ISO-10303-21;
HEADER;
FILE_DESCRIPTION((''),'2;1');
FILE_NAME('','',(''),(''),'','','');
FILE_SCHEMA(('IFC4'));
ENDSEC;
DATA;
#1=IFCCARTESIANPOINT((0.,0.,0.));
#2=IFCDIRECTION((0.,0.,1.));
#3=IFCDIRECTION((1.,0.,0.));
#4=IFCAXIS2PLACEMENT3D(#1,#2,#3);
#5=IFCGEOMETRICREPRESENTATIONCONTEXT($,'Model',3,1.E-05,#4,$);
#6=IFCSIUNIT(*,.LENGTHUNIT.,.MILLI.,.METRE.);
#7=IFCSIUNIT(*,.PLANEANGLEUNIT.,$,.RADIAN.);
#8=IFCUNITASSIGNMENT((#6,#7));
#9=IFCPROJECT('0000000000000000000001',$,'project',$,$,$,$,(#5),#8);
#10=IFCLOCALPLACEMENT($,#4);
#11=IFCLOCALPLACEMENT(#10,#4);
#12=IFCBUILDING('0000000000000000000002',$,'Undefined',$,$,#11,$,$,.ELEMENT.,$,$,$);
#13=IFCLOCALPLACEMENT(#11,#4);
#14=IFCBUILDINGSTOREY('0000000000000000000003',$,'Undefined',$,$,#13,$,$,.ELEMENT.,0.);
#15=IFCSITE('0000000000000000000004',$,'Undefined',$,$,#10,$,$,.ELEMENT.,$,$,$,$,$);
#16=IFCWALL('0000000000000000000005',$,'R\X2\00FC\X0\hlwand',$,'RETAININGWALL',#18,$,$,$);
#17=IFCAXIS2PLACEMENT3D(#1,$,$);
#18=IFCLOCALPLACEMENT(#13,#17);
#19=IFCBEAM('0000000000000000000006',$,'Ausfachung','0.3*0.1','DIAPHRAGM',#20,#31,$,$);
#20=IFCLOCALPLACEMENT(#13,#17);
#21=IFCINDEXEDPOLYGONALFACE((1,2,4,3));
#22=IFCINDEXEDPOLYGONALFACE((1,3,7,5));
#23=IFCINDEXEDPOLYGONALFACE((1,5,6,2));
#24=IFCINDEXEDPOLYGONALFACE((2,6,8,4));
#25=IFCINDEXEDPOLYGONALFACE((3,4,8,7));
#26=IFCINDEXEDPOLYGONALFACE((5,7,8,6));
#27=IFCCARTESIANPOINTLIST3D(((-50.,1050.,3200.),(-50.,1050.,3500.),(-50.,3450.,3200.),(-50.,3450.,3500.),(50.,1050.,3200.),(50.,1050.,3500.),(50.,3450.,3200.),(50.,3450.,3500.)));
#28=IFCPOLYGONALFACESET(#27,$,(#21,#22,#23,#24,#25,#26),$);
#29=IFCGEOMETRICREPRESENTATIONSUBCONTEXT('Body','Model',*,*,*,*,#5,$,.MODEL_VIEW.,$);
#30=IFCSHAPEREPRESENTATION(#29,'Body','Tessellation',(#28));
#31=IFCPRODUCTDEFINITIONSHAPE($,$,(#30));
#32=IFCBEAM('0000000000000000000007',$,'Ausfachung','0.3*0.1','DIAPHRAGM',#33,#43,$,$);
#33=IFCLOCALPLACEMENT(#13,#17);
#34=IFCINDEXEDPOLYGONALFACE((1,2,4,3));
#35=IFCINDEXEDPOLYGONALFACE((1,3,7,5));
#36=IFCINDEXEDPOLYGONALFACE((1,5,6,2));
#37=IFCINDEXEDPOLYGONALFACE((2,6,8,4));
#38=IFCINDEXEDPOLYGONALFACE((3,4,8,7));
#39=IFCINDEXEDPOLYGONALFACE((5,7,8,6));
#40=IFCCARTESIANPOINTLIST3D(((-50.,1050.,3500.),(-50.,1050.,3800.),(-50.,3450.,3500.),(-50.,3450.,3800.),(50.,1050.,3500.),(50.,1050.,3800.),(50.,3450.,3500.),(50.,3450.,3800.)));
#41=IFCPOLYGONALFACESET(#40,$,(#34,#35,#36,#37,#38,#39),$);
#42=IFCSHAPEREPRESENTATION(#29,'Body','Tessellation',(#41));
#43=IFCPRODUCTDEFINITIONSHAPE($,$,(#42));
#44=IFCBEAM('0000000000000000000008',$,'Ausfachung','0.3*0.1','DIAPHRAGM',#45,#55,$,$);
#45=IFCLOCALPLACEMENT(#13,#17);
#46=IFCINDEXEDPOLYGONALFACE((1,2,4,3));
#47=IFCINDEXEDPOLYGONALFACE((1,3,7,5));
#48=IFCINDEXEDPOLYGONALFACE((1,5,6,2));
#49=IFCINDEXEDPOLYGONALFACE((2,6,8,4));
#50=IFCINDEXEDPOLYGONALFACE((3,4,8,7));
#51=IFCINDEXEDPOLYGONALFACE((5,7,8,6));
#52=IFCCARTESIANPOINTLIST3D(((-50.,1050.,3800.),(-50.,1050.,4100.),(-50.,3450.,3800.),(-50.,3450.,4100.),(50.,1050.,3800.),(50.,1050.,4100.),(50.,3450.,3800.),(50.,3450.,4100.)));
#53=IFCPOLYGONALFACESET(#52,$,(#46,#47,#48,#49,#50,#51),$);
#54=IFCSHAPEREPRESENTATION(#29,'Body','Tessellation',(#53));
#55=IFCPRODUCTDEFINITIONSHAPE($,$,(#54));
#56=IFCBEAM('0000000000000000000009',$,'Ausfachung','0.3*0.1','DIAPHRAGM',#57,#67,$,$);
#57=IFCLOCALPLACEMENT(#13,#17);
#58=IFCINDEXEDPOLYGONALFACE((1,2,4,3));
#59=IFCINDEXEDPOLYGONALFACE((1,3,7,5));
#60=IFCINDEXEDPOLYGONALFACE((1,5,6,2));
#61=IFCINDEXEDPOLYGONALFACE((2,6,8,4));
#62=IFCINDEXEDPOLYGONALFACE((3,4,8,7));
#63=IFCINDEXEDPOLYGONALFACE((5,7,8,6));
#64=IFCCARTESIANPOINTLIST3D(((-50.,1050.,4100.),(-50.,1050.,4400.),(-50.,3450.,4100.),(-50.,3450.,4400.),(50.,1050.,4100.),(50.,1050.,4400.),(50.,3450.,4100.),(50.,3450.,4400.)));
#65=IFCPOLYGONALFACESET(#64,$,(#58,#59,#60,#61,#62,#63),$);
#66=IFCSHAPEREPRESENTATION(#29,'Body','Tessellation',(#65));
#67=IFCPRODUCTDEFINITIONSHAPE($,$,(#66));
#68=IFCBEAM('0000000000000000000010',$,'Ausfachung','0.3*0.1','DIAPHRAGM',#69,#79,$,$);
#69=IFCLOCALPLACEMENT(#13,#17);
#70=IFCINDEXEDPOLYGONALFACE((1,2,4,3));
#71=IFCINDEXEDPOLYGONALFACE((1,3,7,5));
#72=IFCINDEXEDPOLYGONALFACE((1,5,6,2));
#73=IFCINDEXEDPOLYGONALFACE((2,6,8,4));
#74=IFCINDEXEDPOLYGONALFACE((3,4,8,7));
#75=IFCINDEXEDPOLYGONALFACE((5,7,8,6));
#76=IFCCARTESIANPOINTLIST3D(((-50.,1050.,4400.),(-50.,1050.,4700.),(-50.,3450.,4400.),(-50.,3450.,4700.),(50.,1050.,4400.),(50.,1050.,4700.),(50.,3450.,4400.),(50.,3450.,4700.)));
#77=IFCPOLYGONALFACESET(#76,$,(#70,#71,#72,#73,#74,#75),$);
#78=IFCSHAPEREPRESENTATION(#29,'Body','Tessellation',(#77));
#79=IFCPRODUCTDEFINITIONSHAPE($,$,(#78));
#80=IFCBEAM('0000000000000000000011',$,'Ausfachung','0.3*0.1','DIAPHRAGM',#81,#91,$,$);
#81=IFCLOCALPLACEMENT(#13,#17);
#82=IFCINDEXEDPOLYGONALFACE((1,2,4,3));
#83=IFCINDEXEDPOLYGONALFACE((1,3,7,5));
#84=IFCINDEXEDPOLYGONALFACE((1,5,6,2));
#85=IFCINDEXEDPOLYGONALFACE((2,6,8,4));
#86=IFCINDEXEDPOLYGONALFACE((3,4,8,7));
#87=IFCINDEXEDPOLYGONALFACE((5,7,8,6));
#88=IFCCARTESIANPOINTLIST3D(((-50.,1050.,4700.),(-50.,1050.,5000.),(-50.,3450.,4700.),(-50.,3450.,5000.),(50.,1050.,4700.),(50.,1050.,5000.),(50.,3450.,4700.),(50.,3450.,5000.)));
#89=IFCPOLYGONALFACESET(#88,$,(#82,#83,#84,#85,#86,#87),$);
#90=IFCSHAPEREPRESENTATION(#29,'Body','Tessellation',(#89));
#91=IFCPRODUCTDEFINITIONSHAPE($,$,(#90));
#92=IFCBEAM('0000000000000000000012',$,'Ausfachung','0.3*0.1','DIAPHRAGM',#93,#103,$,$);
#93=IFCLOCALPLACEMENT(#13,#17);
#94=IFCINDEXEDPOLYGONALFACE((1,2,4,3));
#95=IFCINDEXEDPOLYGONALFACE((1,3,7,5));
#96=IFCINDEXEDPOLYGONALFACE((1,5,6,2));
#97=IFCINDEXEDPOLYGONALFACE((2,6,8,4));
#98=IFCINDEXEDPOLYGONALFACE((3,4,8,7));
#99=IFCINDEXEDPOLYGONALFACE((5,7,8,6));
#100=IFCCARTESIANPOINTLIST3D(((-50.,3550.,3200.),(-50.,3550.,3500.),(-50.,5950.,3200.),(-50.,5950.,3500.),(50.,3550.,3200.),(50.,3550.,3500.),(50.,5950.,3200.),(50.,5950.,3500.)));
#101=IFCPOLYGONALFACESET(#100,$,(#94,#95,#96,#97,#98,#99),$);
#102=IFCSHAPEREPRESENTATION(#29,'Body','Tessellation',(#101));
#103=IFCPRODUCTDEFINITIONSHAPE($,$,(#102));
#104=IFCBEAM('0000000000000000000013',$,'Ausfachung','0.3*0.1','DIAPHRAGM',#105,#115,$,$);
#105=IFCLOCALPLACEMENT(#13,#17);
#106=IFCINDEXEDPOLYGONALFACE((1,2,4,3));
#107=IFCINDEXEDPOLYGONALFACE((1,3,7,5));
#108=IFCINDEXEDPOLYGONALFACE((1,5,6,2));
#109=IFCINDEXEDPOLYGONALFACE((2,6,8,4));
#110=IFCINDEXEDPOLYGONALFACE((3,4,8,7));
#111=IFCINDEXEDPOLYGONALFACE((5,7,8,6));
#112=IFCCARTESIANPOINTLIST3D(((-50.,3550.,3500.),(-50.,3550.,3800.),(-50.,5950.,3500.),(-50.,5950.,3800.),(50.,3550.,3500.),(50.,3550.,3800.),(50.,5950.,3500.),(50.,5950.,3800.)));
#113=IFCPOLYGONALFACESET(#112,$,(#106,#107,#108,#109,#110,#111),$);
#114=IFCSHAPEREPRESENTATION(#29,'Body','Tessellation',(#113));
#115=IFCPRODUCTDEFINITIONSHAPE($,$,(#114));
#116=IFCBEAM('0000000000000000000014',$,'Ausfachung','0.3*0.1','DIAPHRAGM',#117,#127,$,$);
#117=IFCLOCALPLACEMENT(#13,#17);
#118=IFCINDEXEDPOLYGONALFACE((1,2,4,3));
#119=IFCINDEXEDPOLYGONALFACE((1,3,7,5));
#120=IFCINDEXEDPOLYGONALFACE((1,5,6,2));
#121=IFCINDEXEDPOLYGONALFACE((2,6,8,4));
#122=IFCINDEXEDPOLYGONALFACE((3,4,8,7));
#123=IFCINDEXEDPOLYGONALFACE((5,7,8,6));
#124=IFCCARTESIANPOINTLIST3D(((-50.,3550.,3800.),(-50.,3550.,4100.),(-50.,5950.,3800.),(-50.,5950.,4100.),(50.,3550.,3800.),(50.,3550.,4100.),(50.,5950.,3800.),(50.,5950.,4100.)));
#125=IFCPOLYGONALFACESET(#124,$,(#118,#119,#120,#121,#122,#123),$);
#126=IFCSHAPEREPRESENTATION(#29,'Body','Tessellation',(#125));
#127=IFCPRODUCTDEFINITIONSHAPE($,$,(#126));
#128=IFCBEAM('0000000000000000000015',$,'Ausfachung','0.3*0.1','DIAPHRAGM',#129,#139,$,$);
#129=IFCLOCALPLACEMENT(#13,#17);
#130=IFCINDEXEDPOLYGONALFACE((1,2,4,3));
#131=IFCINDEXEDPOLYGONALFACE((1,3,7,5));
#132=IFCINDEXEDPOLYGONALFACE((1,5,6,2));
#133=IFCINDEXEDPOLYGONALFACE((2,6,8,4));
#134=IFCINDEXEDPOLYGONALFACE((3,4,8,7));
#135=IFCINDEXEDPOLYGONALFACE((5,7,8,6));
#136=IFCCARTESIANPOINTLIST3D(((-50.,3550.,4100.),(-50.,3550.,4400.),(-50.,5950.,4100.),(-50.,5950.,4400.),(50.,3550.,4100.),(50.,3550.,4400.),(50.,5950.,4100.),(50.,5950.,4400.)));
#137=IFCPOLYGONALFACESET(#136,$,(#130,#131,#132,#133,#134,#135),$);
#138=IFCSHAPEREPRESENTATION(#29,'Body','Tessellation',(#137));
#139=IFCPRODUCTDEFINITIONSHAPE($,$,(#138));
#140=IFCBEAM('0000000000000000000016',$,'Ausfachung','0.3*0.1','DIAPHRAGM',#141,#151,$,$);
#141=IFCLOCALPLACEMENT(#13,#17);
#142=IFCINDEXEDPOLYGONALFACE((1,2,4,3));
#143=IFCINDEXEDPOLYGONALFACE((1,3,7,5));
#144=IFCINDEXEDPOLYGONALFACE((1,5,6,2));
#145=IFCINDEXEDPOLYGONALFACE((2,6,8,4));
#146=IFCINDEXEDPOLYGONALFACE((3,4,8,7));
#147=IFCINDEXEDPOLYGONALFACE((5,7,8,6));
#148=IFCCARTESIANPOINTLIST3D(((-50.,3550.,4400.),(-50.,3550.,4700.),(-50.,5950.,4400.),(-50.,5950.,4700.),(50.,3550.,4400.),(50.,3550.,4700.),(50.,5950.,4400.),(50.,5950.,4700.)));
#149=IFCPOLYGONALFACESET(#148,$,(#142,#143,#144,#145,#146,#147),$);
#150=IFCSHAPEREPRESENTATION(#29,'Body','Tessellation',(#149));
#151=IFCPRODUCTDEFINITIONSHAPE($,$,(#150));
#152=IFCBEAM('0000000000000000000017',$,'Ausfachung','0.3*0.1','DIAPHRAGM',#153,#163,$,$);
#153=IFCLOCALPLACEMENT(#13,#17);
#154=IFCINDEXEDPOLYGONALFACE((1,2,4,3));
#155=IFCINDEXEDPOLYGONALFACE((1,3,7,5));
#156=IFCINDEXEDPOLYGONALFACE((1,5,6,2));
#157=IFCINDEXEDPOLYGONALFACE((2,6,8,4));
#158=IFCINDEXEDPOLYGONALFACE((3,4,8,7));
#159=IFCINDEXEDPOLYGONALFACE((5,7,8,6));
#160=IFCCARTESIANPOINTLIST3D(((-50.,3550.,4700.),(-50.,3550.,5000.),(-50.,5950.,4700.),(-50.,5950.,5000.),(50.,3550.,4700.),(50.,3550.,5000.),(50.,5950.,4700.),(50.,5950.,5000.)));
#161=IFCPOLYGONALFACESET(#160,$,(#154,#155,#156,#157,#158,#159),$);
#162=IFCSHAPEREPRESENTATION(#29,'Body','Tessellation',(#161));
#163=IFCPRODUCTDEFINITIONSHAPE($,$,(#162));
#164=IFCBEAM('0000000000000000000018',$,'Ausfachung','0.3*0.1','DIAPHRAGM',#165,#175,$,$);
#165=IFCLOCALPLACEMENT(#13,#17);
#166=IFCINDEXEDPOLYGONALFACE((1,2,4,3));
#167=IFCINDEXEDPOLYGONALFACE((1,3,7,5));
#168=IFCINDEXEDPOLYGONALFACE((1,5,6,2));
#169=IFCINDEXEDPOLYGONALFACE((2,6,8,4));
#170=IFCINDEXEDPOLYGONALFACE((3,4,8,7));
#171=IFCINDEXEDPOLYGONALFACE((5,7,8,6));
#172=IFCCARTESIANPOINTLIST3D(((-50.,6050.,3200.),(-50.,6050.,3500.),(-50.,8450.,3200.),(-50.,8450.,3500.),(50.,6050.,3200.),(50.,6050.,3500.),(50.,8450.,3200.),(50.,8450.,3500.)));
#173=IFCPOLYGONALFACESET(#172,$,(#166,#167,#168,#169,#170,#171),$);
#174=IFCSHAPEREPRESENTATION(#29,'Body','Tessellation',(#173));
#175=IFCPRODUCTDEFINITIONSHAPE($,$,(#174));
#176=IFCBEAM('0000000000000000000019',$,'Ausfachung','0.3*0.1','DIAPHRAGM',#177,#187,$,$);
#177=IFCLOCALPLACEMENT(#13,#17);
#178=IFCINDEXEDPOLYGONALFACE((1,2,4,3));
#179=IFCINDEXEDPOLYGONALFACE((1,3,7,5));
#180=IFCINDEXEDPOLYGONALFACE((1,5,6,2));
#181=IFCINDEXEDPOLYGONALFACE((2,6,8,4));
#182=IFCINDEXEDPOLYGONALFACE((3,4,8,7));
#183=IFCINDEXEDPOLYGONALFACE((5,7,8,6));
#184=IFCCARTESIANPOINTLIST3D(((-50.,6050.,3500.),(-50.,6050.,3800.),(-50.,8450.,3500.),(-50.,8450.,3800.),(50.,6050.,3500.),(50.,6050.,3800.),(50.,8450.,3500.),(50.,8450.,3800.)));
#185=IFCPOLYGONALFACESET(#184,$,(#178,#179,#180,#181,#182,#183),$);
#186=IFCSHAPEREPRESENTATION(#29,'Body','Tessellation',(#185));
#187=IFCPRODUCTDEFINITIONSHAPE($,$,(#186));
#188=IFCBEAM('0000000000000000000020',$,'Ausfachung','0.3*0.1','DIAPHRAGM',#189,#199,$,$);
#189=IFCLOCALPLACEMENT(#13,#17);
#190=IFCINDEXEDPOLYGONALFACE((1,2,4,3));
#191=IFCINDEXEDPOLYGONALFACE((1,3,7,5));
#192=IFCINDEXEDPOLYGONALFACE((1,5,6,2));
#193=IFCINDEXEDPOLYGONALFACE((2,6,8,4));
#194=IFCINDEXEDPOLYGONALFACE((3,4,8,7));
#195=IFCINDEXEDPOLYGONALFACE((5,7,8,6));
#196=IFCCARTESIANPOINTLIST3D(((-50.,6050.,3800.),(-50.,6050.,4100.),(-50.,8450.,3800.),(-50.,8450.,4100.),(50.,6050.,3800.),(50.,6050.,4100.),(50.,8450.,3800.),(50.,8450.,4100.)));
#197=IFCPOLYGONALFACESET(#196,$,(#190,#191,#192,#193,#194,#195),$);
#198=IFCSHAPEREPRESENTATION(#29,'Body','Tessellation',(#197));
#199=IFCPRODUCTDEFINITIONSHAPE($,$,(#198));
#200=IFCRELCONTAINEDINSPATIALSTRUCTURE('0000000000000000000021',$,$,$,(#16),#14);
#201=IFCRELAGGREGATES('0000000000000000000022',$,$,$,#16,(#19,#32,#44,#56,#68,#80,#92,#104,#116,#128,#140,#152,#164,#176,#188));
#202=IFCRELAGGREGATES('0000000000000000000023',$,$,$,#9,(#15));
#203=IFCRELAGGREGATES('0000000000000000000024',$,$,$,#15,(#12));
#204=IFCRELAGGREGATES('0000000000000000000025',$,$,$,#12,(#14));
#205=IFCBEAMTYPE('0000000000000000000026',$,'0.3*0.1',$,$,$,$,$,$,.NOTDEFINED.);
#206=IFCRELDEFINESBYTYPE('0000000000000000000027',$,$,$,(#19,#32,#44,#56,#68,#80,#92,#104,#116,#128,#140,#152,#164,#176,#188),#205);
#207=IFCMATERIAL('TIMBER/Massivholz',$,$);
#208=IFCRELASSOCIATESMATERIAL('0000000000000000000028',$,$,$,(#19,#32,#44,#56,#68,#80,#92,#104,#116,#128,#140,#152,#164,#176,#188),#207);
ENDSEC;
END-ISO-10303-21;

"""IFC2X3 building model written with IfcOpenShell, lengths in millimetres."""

from ifc_helpers import new_model, si_unit, frame, origin_with_axes, origin_2d_with_axis, place, context, subcontext, project, spatial, rectangle, extrude, material, type_object, element, aggregate, save


model = new_model("IFC2X3")

# Units and contexts
model_context = context("Model", 3, precision=1e-05, world=origin_with_axes())
body_context = subcontext(model_context, "Body", "Model", "MODEL_VIEW")
ifc_project = project(units=[si_unit("LENGTHUNIT", "METRE", prefix="MILLI"), si_unit("PLANEANGLEUNIT", "RADIAN")], contexts=[model_context])

# Site, building, storey
site_placement = place(None, origin_with_axes())
site = spatial("IfcSite", under=ifc_project, at=site_placement, Name="Undefined", CompositionType="ELEMENT")
building_placement = place(site_placement, origin_with_axes())
building = spatial("IfcBuilding", under=site, at=building_placement, Name="Undefined", CompositionType="ELEMENT")
storey_placement = place(building_placement, origin_with_axes())
storey = spatial("IfcBuildingStorey", under=building, at=storey_placement, Name="Undefined", CompositionType="ELEMENT", Elevation=0.0)

# Wall, beams
wall_placement = place(storey_placement, origin_with_axes())
wall = element("IfcWall", 1, at=wall_placement, inside=storey, Name="Rühlwand", ObjectType="RETAININGWALL")
ifc_material_1 = material(Name="TIMBER/Massivholz")
beam_type = type_object("IfcBeamType", Name="0.3*0.1", PredefinedType="NOTDEFINED")
beam_1_placement = place(wall_placement, frame((0.0, 3450.0, 3350.0), z_axis=(0.0, 0.0, -1.0), x_axis=(0.0, -1.0, 0.0)))
beam_1 = element("IfcBeam", 2, at=beam_1_placement, type_object=beam_type, material=ifc_material_1, Name="Ausfachung", Description="0.3*0.1", ObjectType="DIAPHRAGM", context=body_context, shape_type="SweptSolid", body=[
    extrude(rectangle(XDim=100.0, YDim=300.0, at=origin_2d_with_axis()), frame((2400.0, 0.0, 0.0), z_axis=(-1.0, 0.0, 0.0), x_axis=(0.0, -1.0, 0.0)), (0.0, 0.0, 1.0), 2400.0),
])
beam_2_placement = place(wall_placement, frame((0.0, 3450.0, 3650.0), z_axis=(0.0, 0.0, -1.0), x_axis=(0.0, -1.0, 0.0)))
beam_2 = element("IfcBeam", 3, at=beam_2_placement, type_object=beam_type, material=ifc_material_1, Name="Ausfachung", Description="0.3*0.1", ObjectType="DIAPHRAGM", context=body_context, shape_type="SweptSolid", body=[
    extrude(rectangle(XDim=100.0, YDim=300.0, at=origin_2d_with_axis()), frame((2400.0, 0.0, 0.0), z_axis=(-1.0, 0.0, 0.0), x_axis=(0.0, -1.0, 0.0)), (0.0, 0.0, 1.0), 2400.0),
])
beam_3_placement = place(wall_placement, frame((0.0, 3450.0, 3950.0), z_axis=(0.0, 0.0, -1.0), x_axis=(0.0, -1.0, 0.0)))
beam_3 = element("IfcBeam", 4, at=beam_3_placement, type_object=beam_type, material=ifc_material_1, Name="Ausfachung", Description="0.3*0.1", ObjectType="DIAPHRAGM", context=body_context, shape_type="SweptSolid", body=[
    extrude(rectangle(XDim=100.0, YDim=300.0, at=origin_2d_with_axis()), frame((2400.0, 0.0, 0.0), z_axis=(-1.0, 0.0, 0.0), x_axis=(0.0, -1.0, 0.0)), (0.0, 0.0, 1.0), 2400.0),
])
beam_4_placement = place(wall_placement, frame((0.0, 3450.0, 4250.0), z_axis=(0.0, 0.0, -1.0), x_axis=(0.0, -1.0, 0.0)))
beam_4 = element("IfcBeam", 5, at=beam_4_placement, type_object=beam_type, material=ifc_material_1, Name="Ausfachung", Description="0.3*0.1", ObjectType="DIAPHRAGM", context=body_context, shape_type="SweptSolid", body=[
    extrude(rectangle(XDim=100.0, YDim=300.0, at=origin_2d_with_axis()), frame((2400.0, 0.0, 0.0), z_axis=(-1.0, 0.0, 0.0), x_axis=(0.0, -1.0, 0.0)), (0.0, 0.0, 1.0), 2400.0),
])
beam_5_placement = place(wall_placement, frame((0.0, 3450.0, 4550.0), z_axis=(0.0, 0.0, -1.0), x_axis=(0.0, -1.0, 0.0)))
beam_5 = element("IfcBeam", 6, at=beam_5_placement, type_object=beam_type, material=ifc_material_1, Name="Ausfachung", Description="0.3*0.1", ObjectType="DIAPHRAGM", context=body_context, shape_type="SweptSolid", body=[
    extrude(rectangle(XDim=100.0, YDim=300.0, at=origin_2d_with_axis()), frame((2400.0, 0.0, 0.0), z_axis=(-1.0, 0.0, 0.0), x_axis=(0.0, -1.0, 0.0)), (0.0, 0.0, 1.0), 2400.0),
])
beam_6_placement = place(wall_placement, frame((0.0, 3450.0, 4850.0), z_axis=(0.0, 0.0, -1.0), x_axis=(0.0, -1.0, 0.0)))
beam_6 = element("IfcBeam", 7, at=beam_6_placement, type_object=beam_type, material=ifc_material_1, Name="Ausfachung", Description="0.3*0.1", ObjectType="DIAPHRAGM", context=body_context, shape_type="SweptSolid", body=[
    extrude(rectangle(XDim=100.0, YDim=300.0, at=origin_2d_with_axis()), frame((2400.0, 0.0, 0.0), z_axis=(-1.0, 0.0, 0.0), x_axis=(0.0, -1.0, 0.0)), (0.0, 0.0, 1.0), 2400.0),
])
beam_7_placement = place(wall_placement, frame((0.0, 5950.0, 3350.0), z_axis=(0.0, 0.0, -1.0), x_axis=(0.0, -1.0, 0.0)))
beam_7 = element("IfcBeam", 8, at=beam_7_placement, type_object=beam_type, material=ifc_material_1, Name="Ausfachung", Description="0.3*0.1", ObjectType="DIAPHRAGM", context=body_context, shape_type="SweptSolid", body=[
    extrude(rectangle(XDim=100.0, YDim=300.0, at=origin_2d_with_axis()), frame((2400.0, 0.0, 0.0), z_axis=(-1.0, 0.0, 0.0), x_axis=(0.0, -1.0, 0.0)), (0.0, 0.0, 1.0), 2400.0),
])
beam_8_placement = place(wall_placement, frame((0.0, 5950.0, 3650.0), z_axis=(0.0, 0.0, -1.0), x_axis=(0.0, -1.0, 0.0)))
beam_8 = element("IfcBeam", 9, at=beam_8_placement, type_object=beam_type, material=ifc_material_1, Name="Ausfachung", Description="0.3*0.1", ObjectType="DIAPHRAGM", context=body_context, shape_type="SweptSolid", body=[
    extrude(rectangle(XDim=100.0, YDim=300.0, at=origin_2d_with_axis()), frame((2400.0, 0.0, 0.0), z_axis=(-1.0, 0.0, 0.0), x_axis=(0.0, -1.0, 0.0)), (0.0, 0.0, 1.0), 2400.0),
])
beam_9_placement = place(wall_placement, frame((0.0, 5950.0, 3950.0), z_axis=(0.0, 0.0, -1.0), x_axis=(0.0, -1.0, 0.0)))
beam_9 = element("IfcBeam", 10, at=beam_9_placement, type_object=beam_type, material=ifc_material_1, Name="Ausfachung", Description="0.3*0.1", ObjectType="DIAPHRAGM", context=body_context, shape_type="SweptSolid", body=[
    extrude(rectangle(XDim=100.0, YDim=300.0, at=origin_2d_with_axis()), frame((2400.0, 0.0, 0.0), z_axis=(-1.0, 0.0, 0.0), x_axis=(0.0, -1.0, 0.0)), (0.0, 0.0, 1.0), 2400.0),
])
beam_10_placement = place(wall_placement, frame((0.0, 5950.0, 4250.0), z_axis=(0.0, 0.0, -1.0), x_axis=(0.0, -1.0, 0.0)))
beam_10 = element("IfcBeam", 11, at=beam_10_placement, type_object=beam_type, material=ifc_material_1, Name="Ausfachung", Description="0.3*0.1", ObjectType="DIAPHRAGM", context=body_context, shape_type="SweptSolid", body=[
    extrude(rectangle(XDim=100.0, YDim=300.0, at=origin_2d_with_axis()), frame((2400.0, 0.0, 0.0), z_axis=(-1.0, 0.0, 0.0), x_axis=(0.0, -1.0, 0.0)), (0.0, 0.0, 1.0), 2400.0),
])
beam_11_placement = place(wall_placement, frame((0.0, 5950.0, 4550.0), z_axis=(0.0, 0.0, -1.0), x_axis=(0.0, -1.0, 0.0)))
beam_11 = element("IfcBeam", 12, at=beam_11_placement, type_object=beam_type, material=ifc_material_1, Name="Ausfachung", Description="0.3*0.1", ObjectType="DIAPHRAGM", context=body_context, shape_type="SweptSolid", body=[
    extrude(rectangle(XDim=100.0, YDim=300.0, at=origin_2d_with_axis()), frame((2400.0, 0.0, 0.0), z_axis=(-1.0, 0.0, 0.0), x_axis=(0.0, -1.0, 0.0)), (0.0, 0.0, 1.0), 2400.0),
])
beam_12_placement = place(wall_placement, frame((0.0, 5950.0, 4850.0), z_axis=(0.0, 0.0, -1.0), x_axis=(0.0, -1.0, 0.0)))
beam_12 = element("IfcBeam", 13, at=beam_12_placement, type_object=beam_type, material=ifc_material_1, Name="Ausfachung", Description="0.3*0.1", ObjectType="DIAPHRAGM", context=body_context, shape_type="SweptSolid", body=[
    extrude(rectangle(XDim=100.0, YDim=300.0, at=origin_2d_with_axis()), frame((2400.0, 0.0, 0.0), z_axis=(-1.0, 0.0, 0.0), x_axis=(0.0, -1.0, 0.0)), (0.0, 0.0, 1.0), 2400.0),
])
beam_13_placement = place(wall_placement, frame((0.0, 8450.0, 3350.0), z_axis=(0.0, 0.0, -1.0), x_axis=(0.0, -1.0, 0.0)))
beam_13 = element("IfcBeam", 14, at=beam_13_placement, type_object=beam_type, material=ifc_material_1, Name="Ausfachung", Description="0.3*0.1", ObjectType="DIAPHRAGM", context=body_context, shape_type="SweptSolid", body=[
    extrude(rectangle(XDim=100.0, YDim=300.0, at=origin_2d_with_axis()), frame((2400.0, 0.0, 0.0), z_axis=(-1.0, 0.0, 0.0), x_axis=(0.0, -1.0, 0.0)), (0.0, 0.0, 1.0), 2400.0),
])
beam_14_placement = place(wall_placement, frame((0.0, 8450.0, 3650.0), z_axis=(0.0, 0.0, -1.0), x_axis=(0.0, -1.0, 0.0)))
beam_14 = element("IfcBeam", 15, at=beam_14_placement, type_object=beam_type, material=ifc_material_1, Name="Ausfachung", Description="0.3*0.1", ObjectType="DIAPHRAGM", context=body_context, shape_type="SweptSolid", body=[
    extrude(rectangle(XDim=100.0, YDim=300.0, at=origin_2d_with_axis()), frame((2400.0, 0.0, 0.0), z_axis=(-1.0, 0.0, 0.0), x_axis=(0.0, -1.0, 0.0)), (0.0, 0.0, 1.0), 2400.0),
])
beam_15_placement = place(wall_placement, frame((0.0, 8450.0, 3950.0), z_axis=(0.0, 0.0, -1.0), x_axis=(0.0, -1.0, 0.0)))
beam_15 = element("IfcBeam", 16, at=beam_15_placement, type_object=beam_type, material=ifc_material_1, Name="Ausfachung", Description="0.3*0.1", ObjectType="DIAPHRAGM", context=body_context, shape_type="SweptSolid", body=[
    extrude(rectangle(XDim=100.0, YDim=300.0, at=origin_2d_with_axis()), frame((2400.0, 0.0, 0.0), z_axis=(-1.0, 0.0, 0.0), x_axis=(0.0, -1.0, 0.0)), (0.0, 0.0, 1.0), 2400.0),
])
aggregate(wall, [beam_1, beam_2, beam_3, beam_4, beam_5, beam_6, beam_7, beam_8, beam_9, beam_10, beam_11, beam_12, beam_13, beam_14, beam_15])

save(model, "model.ifc")
